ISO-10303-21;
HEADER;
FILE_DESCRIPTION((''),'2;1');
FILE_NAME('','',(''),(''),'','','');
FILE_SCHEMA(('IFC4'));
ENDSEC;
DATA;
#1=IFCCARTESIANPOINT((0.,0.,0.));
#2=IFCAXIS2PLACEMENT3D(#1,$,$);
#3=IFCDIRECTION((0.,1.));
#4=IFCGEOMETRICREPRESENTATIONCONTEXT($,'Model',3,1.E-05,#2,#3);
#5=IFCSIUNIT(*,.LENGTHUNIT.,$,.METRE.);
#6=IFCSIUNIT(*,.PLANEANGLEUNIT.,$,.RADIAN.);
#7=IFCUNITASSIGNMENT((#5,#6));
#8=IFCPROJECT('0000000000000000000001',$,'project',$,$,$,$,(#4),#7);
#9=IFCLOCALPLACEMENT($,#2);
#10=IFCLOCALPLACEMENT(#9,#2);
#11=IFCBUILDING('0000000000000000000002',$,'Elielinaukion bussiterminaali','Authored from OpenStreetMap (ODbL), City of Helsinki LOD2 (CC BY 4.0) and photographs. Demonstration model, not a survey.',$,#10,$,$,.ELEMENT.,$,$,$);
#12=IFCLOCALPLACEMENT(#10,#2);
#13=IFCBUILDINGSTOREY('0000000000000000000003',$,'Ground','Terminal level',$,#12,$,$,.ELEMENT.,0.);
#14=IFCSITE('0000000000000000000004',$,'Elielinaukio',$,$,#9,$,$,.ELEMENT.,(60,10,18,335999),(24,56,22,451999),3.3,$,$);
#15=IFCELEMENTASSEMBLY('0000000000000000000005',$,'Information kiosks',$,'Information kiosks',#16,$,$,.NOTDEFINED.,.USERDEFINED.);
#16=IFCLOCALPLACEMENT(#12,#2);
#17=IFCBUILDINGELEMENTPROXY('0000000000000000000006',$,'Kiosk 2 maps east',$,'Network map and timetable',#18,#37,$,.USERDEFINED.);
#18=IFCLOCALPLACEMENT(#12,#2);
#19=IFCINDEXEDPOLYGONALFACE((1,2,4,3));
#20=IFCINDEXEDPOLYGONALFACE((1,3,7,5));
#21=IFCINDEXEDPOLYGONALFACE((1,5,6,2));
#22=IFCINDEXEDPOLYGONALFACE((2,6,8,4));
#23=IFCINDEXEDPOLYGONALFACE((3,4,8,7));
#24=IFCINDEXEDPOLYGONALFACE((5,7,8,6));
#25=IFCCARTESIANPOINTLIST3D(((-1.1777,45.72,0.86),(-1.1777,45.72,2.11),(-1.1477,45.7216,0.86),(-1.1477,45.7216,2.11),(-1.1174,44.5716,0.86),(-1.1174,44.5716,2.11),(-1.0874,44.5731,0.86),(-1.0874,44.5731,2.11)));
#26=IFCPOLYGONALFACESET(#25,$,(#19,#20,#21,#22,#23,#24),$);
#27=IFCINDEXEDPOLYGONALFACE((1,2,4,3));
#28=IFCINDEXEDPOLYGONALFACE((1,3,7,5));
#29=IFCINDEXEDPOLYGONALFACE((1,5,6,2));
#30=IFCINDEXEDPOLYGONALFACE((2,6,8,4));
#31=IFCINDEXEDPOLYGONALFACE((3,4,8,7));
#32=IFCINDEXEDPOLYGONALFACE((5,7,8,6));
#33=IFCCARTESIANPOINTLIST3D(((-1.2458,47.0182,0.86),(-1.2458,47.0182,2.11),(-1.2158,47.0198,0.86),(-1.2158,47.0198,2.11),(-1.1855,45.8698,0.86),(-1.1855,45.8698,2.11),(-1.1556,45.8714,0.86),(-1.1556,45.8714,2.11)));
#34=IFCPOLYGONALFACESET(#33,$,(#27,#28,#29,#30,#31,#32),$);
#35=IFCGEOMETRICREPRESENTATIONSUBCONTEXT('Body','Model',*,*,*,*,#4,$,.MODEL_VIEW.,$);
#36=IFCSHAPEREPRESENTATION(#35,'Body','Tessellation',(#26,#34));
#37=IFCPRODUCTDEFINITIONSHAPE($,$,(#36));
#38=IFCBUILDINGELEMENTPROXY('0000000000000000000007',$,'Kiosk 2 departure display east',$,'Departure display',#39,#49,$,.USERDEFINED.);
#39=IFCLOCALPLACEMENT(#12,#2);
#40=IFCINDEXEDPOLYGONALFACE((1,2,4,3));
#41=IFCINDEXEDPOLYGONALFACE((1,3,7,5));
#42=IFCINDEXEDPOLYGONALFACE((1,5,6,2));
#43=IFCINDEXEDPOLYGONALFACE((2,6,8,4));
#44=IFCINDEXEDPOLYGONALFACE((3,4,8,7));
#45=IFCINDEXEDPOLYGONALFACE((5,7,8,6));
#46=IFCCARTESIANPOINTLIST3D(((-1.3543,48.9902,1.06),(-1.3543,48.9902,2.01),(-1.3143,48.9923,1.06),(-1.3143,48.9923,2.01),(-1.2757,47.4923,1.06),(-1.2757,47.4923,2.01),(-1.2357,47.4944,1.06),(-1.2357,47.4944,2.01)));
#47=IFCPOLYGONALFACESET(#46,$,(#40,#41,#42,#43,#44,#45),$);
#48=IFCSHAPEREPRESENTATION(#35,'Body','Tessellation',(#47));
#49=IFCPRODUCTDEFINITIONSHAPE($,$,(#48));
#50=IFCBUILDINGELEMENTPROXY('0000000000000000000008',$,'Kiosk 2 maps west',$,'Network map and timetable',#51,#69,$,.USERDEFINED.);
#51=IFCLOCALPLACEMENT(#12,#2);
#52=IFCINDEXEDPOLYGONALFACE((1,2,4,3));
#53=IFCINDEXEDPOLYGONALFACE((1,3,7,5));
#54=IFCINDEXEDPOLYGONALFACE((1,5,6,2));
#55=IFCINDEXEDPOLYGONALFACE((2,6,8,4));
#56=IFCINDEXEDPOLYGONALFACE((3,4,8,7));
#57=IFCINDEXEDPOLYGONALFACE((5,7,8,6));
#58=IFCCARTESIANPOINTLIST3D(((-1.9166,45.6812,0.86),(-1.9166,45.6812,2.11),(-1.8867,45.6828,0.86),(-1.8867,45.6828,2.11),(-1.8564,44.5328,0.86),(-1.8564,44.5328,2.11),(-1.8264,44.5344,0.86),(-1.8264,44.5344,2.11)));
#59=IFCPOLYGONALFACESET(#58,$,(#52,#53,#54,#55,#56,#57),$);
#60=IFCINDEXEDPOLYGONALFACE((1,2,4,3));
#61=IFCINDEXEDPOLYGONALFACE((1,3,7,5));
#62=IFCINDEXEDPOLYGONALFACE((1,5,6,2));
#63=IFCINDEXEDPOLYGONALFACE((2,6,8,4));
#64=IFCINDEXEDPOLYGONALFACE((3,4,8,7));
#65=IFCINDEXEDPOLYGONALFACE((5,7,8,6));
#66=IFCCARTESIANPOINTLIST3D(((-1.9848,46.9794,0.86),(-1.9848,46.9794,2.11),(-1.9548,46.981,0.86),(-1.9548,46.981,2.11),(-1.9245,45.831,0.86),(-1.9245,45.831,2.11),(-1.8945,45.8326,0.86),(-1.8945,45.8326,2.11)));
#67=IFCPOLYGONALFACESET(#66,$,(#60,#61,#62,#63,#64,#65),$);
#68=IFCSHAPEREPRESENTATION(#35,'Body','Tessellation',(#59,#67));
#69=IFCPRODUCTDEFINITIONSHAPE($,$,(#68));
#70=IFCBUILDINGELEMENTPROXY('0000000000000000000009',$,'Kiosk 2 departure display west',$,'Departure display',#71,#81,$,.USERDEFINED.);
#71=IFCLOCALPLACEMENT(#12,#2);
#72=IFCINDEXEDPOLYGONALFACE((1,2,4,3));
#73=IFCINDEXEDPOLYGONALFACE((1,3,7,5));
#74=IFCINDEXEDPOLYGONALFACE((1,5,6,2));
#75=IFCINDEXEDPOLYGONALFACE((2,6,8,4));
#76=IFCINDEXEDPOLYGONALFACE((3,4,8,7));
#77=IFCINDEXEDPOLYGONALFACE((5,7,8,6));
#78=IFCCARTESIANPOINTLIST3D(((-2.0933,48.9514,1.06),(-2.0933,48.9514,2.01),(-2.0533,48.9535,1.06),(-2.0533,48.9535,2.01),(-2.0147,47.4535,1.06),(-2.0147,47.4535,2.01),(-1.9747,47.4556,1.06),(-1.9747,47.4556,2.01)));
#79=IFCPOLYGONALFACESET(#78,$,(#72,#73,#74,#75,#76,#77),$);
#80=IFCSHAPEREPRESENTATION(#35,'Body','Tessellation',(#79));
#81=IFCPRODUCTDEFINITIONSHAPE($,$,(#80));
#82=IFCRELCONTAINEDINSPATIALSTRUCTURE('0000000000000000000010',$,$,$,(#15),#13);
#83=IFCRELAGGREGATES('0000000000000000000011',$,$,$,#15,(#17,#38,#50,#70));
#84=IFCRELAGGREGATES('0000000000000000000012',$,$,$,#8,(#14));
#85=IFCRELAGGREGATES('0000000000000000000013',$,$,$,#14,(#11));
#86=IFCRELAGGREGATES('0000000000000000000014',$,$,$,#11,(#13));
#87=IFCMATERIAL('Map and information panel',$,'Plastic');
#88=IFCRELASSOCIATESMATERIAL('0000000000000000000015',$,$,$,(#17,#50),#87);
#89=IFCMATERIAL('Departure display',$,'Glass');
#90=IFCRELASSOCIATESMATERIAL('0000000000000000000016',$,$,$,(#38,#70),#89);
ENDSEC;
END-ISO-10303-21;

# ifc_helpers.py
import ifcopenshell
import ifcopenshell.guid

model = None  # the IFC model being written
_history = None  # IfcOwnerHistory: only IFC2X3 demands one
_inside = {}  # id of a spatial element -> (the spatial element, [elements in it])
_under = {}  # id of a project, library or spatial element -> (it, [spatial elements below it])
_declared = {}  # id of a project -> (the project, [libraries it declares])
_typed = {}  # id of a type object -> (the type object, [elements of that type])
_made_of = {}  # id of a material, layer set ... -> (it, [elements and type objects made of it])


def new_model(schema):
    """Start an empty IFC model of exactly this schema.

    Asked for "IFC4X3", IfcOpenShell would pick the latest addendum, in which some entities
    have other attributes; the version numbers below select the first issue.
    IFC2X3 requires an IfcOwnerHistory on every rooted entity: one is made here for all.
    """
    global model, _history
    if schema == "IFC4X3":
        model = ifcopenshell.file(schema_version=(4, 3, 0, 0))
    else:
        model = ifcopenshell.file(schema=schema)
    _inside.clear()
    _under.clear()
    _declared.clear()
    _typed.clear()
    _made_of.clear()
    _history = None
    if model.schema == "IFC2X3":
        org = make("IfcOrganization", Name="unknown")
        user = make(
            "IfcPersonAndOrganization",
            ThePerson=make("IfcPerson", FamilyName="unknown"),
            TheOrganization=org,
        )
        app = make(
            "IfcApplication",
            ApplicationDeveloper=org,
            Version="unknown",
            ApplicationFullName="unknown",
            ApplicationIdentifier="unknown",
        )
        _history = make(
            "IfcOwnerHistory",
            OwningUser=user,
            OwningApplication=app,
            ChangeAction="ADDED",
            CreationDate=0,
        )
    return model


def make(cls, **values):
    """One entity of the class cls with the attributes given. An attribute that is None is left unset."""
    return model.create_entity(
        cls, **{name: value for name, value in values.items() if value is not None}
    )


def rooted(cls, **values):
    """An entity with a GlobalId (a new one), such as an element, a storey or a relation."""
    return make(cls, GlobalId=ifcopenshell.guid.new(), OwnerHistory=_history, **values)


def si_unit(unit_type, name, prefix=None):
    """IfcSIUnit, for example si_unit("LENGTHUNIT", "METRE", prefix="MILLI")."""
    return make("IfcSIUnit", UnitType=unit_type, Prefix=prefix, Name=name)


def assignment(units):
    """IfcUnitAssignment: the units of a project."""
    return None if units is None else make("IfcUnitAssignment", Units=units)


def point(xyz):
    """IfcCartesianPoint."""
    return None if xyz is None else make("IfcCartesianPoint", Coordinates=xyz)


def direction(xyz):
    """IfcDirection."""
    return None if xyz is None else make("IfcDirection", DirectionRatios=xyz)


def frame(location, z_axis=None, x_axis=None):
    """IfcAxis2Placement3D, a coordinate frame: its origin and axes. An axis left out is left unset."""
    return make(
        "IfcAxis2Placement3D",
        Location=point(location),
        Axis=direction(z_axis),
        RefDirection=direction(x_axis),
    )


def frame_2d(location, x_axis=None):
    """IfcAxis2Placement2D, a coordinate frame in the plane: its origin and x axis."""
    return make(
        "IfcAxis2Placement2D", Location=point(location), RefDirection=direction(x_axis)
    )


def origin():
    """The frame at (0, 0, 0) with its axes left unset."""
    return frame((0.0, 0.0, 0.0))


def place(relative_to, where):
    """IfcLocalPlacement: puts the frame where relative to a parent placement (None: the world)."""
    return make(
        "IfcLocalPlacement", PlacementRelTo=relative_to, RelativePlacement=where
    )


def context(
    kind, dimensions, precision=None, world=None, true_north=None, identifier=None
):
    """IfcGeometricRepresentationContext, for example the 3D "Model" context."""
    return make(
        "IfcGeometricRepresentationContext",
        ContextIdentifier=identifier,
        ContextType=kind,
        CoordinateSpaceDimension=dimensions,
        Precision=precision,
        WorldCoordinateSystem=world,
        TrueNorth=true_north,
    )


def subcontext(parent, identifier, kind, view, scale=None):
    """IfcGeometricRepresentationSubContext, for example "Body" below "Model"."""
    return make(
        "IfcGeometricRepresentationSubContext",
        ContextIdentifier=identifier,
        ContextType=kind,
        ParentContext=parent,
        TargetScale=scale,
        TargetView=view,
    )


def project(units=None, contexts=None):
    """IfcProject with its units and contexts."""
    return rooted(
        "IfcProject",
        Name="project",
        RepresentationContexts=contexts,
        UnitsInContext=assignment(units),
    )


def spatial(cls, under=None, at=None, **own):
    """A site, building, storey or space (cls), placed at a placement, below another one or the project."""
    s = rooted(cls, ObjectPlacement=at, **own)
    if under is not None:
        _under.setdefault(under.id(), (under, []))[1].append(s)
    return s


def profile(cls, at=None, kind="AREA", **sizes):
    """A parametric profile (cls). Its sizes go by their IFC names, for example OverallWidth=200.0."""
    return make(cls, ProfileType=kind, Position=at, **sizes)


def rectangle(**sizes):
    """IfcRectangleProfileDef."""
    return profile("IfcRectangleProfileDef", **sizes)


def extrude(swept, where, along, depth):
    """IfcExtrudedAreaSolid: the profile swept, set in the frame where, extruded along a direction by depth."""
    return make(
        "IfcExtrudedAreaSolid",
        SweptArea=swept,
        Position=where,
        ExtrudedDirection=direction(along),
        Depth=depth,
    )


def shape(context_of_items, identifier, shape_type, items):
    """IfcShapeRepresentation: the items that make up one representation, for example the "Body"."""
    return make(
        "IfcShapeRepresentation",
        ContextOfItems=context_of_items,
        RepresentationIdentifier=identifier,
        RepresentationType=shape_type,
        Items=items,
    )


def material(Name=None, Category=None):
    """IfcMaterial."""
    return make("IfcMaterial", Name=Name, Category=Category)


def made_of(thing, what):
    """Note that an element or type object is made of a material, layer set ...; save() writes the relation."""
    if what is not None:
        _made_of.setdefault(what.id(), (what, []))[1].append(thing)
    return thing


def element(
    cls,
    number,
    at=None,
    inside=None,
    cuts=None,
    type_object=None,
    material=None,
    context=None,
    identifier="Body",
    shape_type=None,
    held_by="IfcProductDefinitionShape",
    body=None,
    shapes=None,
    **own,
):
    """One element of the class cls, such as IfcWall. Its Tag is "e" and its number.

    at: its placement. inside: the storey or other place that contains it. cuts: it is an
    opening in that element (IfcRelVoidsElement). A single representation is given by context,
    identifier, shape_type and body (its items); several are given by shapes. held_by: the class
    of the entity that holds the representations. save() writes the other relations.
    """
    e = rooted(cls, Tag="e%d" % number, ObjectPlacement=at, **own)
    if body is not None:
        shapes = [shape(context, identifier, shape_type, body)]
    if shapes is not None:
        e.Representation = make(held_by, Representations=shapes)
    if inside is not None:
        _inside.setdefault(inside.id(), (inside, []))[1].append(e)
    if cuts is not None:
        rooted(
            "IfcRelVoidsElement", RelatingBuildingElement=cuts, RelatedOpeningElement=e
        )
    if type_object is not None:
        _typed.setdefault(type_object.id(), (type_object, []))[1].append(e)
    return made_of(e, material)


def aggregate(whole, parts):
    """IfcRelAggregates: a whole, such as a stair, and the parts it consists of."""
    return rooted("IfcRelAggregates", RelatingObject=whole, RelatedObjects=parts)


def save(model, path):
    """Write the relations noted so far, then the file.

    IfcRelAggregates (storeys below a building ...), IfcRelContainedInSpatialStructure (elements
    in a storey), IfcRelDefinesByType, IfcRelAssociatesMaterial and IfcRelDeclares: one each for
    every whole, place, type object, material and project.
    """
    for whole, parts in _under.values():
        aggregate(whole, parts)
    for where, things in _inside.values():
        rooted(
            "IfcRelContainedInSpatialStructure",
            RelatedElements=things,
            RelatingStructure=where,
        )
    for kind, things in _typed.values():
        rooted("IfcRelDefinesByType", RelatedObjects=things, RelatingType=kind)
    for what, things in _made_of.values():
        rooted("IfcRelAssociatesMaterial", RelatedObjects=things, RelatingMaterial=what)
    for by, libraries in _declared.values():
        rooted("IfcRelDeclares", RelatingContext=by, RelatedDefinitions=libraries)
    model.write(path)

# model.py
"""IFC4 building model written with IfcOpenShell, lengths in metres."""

from ifc_helpers import new_model, si_unit, direction, frame, frame_2d, origin, place, context, subcontext, project, spatial, rectangle, extrude, material, element, aggregate, save


model = new_model("IFC4")

# Units and contexts
model_context = context("Model", 3, precision=1e-05, world=origin(), true_north=direction((0.0, 1.0)))
body_context = subcontext(model_context, "Body", "Model", "MODEL_VIEW")
ifc_project = project(units=[si_unit("LENGTHUNIT", "METRE"), si_unit("PLANEANGLEUNIT", "RADIAN")], contexts=[model_context])

# Site, building, storey
site_placement = place(None, origin())
site = spatial("IfcSite", under=ifc_project, at=site_placement, Name="Elielinaukio", CompositionType="ELEMENT", RefLatitude=(60, 10, 18, 335999), RefLongitude=(24, 56, 22, 451999), RefElevation=3.3)
building_placement = place(site_placement, origin())
building = spatial("IfcBuilding", under=site, at=building_placement, Name="Elielinaukion bussiterminaali", Description="Authored from OpenStreetMap (ODbL), City of Helsinki LOD2 (CC BY 4.0) and photographs. Demonstration model, not a survey.", CompositionType="ELEMENT")
storey_placement = place(building_placement, origin())
storey = spatial("IfcBuildingStorey", under=building, at=storey_placement, Name="Ground", Description="Terminal level", CompositionType="ELEMENT", Elevation=0.0)

# Element assembly
assembly_1_placement = place(building_placement, origin())
assembly_1 = element("IfcElementAssembly", 1, at=assembly_1_placement, inside=storey, Name="Information kiosks", ObjectType="Information kiosks", AssemblyPlace="NOTDEFINED", PredefinedType="USERDEFINED")

# Building element proxies
ifc_material_1 = material(Name="Map and information panel", Category="Plastic")
ifc_material_2 = material(Name="Departure display", Category="Glass")
proxy_1_placement = place(building_placement, origin())
proxy_1 = element("IfcBuildingElementProxy", 2, at=proxy_1_placement, material=ifc_material_1, Name="Kiosk 2 maps east", ObjectType="Network map and timetable", PredefinedType="USERDEFINED", context=body_context, shape_type="SweptSolid", body=[
    extrude(rectangle(XDim=1.15, YDim=0.03, at=frame_2d((0.0, 0.0), x_axis=(-0.052408, 0.998626))), frame((-1.1325, 45.1466, 0.86)), (0.0, 0.0, 1.0), 1.25),
    extrude(rectangle(XDim=1.15, YDim=0.03, at=frame_2d((0.0, 0.0), x_axis=(-0.052408, 0.998626))), frame((-1.2007, 46.4448, 0.86)), (0.0, 0.0, 1.0), 1.25),
])
proxy_2_placement = place(building_placement, origin())
proxy_2 = element("IfcBuildingElementProxy", 3, at=proxy_2_placement, material=ifc_material_2, Name="Kiosk 2 departure display east", ObjectType="Departure display", PredefinedType="USERDEFINED", context=body_context, shape_type="SweptSolid", body=[
    extrude(rectangle(XDim=1.5, YDim=0.04, at=frame_2d((0.0, 0.0), x_axis=(-0.052408, 0.998626))), frame((-1.295, 48.2423, 1.06)), (0.0, 0.0, 1.0), 0.95),
])
proxy_3_placement = place(building_placement, origin())
proxy_3 = element("IfcBuildingElementProxy", 4, at=proxy_3_placement, material=ifc_material_1, Name="Kiosk 2 maps west", ObjectType="Network map and timetable", PredefinedType="USERDEFINED", context=body_context, shape_type="SweptSolid", body=[
    extrude(rectangle(XDim=1.15, YDim=0.03, at=frame_2d((0.0, 0.0), x_axis=(-0.052408, 0.998626))), frame((-1.8715, 45.1078, 0.86)), (0.0, 0.0, 1.0), 1.25),
    extrude(rectangle(XDim=1.15, YDim=0.03, at=frame_2d((0.0, 0.0), x_axis=(-0.052408, 0.998626))), frame((-1.9397, 46.406, 0.86)), (0.0, 0.0, 1.0), 1.25),
])
proxy_4_placement = place(building_placement, origin())
proxy_4 = element("IfcBuildingElementProxy", 5, at=proxy_4_placement, material=ifc_material_2, Name="Kiosk 2 departure display west", ObjectType="Departure display", PredefinedType="USERDEFINED", context=body_context, shape_type="SweptSolid", body=[
    extrude(rectangle(XDim=1.5, YDim=0.04, at=frame_2d((0.0, 0.0), x_axis=(-0.052408, 0.998626))), frame((-2.034, 48.2035, 1.06)), (0.0, 0.0, 1.0), 0.95),
])
aggregate(assembly_1, [proxy_1, proxy_2, proxy_3, proxy_4])

save(model, "model.ifc")
